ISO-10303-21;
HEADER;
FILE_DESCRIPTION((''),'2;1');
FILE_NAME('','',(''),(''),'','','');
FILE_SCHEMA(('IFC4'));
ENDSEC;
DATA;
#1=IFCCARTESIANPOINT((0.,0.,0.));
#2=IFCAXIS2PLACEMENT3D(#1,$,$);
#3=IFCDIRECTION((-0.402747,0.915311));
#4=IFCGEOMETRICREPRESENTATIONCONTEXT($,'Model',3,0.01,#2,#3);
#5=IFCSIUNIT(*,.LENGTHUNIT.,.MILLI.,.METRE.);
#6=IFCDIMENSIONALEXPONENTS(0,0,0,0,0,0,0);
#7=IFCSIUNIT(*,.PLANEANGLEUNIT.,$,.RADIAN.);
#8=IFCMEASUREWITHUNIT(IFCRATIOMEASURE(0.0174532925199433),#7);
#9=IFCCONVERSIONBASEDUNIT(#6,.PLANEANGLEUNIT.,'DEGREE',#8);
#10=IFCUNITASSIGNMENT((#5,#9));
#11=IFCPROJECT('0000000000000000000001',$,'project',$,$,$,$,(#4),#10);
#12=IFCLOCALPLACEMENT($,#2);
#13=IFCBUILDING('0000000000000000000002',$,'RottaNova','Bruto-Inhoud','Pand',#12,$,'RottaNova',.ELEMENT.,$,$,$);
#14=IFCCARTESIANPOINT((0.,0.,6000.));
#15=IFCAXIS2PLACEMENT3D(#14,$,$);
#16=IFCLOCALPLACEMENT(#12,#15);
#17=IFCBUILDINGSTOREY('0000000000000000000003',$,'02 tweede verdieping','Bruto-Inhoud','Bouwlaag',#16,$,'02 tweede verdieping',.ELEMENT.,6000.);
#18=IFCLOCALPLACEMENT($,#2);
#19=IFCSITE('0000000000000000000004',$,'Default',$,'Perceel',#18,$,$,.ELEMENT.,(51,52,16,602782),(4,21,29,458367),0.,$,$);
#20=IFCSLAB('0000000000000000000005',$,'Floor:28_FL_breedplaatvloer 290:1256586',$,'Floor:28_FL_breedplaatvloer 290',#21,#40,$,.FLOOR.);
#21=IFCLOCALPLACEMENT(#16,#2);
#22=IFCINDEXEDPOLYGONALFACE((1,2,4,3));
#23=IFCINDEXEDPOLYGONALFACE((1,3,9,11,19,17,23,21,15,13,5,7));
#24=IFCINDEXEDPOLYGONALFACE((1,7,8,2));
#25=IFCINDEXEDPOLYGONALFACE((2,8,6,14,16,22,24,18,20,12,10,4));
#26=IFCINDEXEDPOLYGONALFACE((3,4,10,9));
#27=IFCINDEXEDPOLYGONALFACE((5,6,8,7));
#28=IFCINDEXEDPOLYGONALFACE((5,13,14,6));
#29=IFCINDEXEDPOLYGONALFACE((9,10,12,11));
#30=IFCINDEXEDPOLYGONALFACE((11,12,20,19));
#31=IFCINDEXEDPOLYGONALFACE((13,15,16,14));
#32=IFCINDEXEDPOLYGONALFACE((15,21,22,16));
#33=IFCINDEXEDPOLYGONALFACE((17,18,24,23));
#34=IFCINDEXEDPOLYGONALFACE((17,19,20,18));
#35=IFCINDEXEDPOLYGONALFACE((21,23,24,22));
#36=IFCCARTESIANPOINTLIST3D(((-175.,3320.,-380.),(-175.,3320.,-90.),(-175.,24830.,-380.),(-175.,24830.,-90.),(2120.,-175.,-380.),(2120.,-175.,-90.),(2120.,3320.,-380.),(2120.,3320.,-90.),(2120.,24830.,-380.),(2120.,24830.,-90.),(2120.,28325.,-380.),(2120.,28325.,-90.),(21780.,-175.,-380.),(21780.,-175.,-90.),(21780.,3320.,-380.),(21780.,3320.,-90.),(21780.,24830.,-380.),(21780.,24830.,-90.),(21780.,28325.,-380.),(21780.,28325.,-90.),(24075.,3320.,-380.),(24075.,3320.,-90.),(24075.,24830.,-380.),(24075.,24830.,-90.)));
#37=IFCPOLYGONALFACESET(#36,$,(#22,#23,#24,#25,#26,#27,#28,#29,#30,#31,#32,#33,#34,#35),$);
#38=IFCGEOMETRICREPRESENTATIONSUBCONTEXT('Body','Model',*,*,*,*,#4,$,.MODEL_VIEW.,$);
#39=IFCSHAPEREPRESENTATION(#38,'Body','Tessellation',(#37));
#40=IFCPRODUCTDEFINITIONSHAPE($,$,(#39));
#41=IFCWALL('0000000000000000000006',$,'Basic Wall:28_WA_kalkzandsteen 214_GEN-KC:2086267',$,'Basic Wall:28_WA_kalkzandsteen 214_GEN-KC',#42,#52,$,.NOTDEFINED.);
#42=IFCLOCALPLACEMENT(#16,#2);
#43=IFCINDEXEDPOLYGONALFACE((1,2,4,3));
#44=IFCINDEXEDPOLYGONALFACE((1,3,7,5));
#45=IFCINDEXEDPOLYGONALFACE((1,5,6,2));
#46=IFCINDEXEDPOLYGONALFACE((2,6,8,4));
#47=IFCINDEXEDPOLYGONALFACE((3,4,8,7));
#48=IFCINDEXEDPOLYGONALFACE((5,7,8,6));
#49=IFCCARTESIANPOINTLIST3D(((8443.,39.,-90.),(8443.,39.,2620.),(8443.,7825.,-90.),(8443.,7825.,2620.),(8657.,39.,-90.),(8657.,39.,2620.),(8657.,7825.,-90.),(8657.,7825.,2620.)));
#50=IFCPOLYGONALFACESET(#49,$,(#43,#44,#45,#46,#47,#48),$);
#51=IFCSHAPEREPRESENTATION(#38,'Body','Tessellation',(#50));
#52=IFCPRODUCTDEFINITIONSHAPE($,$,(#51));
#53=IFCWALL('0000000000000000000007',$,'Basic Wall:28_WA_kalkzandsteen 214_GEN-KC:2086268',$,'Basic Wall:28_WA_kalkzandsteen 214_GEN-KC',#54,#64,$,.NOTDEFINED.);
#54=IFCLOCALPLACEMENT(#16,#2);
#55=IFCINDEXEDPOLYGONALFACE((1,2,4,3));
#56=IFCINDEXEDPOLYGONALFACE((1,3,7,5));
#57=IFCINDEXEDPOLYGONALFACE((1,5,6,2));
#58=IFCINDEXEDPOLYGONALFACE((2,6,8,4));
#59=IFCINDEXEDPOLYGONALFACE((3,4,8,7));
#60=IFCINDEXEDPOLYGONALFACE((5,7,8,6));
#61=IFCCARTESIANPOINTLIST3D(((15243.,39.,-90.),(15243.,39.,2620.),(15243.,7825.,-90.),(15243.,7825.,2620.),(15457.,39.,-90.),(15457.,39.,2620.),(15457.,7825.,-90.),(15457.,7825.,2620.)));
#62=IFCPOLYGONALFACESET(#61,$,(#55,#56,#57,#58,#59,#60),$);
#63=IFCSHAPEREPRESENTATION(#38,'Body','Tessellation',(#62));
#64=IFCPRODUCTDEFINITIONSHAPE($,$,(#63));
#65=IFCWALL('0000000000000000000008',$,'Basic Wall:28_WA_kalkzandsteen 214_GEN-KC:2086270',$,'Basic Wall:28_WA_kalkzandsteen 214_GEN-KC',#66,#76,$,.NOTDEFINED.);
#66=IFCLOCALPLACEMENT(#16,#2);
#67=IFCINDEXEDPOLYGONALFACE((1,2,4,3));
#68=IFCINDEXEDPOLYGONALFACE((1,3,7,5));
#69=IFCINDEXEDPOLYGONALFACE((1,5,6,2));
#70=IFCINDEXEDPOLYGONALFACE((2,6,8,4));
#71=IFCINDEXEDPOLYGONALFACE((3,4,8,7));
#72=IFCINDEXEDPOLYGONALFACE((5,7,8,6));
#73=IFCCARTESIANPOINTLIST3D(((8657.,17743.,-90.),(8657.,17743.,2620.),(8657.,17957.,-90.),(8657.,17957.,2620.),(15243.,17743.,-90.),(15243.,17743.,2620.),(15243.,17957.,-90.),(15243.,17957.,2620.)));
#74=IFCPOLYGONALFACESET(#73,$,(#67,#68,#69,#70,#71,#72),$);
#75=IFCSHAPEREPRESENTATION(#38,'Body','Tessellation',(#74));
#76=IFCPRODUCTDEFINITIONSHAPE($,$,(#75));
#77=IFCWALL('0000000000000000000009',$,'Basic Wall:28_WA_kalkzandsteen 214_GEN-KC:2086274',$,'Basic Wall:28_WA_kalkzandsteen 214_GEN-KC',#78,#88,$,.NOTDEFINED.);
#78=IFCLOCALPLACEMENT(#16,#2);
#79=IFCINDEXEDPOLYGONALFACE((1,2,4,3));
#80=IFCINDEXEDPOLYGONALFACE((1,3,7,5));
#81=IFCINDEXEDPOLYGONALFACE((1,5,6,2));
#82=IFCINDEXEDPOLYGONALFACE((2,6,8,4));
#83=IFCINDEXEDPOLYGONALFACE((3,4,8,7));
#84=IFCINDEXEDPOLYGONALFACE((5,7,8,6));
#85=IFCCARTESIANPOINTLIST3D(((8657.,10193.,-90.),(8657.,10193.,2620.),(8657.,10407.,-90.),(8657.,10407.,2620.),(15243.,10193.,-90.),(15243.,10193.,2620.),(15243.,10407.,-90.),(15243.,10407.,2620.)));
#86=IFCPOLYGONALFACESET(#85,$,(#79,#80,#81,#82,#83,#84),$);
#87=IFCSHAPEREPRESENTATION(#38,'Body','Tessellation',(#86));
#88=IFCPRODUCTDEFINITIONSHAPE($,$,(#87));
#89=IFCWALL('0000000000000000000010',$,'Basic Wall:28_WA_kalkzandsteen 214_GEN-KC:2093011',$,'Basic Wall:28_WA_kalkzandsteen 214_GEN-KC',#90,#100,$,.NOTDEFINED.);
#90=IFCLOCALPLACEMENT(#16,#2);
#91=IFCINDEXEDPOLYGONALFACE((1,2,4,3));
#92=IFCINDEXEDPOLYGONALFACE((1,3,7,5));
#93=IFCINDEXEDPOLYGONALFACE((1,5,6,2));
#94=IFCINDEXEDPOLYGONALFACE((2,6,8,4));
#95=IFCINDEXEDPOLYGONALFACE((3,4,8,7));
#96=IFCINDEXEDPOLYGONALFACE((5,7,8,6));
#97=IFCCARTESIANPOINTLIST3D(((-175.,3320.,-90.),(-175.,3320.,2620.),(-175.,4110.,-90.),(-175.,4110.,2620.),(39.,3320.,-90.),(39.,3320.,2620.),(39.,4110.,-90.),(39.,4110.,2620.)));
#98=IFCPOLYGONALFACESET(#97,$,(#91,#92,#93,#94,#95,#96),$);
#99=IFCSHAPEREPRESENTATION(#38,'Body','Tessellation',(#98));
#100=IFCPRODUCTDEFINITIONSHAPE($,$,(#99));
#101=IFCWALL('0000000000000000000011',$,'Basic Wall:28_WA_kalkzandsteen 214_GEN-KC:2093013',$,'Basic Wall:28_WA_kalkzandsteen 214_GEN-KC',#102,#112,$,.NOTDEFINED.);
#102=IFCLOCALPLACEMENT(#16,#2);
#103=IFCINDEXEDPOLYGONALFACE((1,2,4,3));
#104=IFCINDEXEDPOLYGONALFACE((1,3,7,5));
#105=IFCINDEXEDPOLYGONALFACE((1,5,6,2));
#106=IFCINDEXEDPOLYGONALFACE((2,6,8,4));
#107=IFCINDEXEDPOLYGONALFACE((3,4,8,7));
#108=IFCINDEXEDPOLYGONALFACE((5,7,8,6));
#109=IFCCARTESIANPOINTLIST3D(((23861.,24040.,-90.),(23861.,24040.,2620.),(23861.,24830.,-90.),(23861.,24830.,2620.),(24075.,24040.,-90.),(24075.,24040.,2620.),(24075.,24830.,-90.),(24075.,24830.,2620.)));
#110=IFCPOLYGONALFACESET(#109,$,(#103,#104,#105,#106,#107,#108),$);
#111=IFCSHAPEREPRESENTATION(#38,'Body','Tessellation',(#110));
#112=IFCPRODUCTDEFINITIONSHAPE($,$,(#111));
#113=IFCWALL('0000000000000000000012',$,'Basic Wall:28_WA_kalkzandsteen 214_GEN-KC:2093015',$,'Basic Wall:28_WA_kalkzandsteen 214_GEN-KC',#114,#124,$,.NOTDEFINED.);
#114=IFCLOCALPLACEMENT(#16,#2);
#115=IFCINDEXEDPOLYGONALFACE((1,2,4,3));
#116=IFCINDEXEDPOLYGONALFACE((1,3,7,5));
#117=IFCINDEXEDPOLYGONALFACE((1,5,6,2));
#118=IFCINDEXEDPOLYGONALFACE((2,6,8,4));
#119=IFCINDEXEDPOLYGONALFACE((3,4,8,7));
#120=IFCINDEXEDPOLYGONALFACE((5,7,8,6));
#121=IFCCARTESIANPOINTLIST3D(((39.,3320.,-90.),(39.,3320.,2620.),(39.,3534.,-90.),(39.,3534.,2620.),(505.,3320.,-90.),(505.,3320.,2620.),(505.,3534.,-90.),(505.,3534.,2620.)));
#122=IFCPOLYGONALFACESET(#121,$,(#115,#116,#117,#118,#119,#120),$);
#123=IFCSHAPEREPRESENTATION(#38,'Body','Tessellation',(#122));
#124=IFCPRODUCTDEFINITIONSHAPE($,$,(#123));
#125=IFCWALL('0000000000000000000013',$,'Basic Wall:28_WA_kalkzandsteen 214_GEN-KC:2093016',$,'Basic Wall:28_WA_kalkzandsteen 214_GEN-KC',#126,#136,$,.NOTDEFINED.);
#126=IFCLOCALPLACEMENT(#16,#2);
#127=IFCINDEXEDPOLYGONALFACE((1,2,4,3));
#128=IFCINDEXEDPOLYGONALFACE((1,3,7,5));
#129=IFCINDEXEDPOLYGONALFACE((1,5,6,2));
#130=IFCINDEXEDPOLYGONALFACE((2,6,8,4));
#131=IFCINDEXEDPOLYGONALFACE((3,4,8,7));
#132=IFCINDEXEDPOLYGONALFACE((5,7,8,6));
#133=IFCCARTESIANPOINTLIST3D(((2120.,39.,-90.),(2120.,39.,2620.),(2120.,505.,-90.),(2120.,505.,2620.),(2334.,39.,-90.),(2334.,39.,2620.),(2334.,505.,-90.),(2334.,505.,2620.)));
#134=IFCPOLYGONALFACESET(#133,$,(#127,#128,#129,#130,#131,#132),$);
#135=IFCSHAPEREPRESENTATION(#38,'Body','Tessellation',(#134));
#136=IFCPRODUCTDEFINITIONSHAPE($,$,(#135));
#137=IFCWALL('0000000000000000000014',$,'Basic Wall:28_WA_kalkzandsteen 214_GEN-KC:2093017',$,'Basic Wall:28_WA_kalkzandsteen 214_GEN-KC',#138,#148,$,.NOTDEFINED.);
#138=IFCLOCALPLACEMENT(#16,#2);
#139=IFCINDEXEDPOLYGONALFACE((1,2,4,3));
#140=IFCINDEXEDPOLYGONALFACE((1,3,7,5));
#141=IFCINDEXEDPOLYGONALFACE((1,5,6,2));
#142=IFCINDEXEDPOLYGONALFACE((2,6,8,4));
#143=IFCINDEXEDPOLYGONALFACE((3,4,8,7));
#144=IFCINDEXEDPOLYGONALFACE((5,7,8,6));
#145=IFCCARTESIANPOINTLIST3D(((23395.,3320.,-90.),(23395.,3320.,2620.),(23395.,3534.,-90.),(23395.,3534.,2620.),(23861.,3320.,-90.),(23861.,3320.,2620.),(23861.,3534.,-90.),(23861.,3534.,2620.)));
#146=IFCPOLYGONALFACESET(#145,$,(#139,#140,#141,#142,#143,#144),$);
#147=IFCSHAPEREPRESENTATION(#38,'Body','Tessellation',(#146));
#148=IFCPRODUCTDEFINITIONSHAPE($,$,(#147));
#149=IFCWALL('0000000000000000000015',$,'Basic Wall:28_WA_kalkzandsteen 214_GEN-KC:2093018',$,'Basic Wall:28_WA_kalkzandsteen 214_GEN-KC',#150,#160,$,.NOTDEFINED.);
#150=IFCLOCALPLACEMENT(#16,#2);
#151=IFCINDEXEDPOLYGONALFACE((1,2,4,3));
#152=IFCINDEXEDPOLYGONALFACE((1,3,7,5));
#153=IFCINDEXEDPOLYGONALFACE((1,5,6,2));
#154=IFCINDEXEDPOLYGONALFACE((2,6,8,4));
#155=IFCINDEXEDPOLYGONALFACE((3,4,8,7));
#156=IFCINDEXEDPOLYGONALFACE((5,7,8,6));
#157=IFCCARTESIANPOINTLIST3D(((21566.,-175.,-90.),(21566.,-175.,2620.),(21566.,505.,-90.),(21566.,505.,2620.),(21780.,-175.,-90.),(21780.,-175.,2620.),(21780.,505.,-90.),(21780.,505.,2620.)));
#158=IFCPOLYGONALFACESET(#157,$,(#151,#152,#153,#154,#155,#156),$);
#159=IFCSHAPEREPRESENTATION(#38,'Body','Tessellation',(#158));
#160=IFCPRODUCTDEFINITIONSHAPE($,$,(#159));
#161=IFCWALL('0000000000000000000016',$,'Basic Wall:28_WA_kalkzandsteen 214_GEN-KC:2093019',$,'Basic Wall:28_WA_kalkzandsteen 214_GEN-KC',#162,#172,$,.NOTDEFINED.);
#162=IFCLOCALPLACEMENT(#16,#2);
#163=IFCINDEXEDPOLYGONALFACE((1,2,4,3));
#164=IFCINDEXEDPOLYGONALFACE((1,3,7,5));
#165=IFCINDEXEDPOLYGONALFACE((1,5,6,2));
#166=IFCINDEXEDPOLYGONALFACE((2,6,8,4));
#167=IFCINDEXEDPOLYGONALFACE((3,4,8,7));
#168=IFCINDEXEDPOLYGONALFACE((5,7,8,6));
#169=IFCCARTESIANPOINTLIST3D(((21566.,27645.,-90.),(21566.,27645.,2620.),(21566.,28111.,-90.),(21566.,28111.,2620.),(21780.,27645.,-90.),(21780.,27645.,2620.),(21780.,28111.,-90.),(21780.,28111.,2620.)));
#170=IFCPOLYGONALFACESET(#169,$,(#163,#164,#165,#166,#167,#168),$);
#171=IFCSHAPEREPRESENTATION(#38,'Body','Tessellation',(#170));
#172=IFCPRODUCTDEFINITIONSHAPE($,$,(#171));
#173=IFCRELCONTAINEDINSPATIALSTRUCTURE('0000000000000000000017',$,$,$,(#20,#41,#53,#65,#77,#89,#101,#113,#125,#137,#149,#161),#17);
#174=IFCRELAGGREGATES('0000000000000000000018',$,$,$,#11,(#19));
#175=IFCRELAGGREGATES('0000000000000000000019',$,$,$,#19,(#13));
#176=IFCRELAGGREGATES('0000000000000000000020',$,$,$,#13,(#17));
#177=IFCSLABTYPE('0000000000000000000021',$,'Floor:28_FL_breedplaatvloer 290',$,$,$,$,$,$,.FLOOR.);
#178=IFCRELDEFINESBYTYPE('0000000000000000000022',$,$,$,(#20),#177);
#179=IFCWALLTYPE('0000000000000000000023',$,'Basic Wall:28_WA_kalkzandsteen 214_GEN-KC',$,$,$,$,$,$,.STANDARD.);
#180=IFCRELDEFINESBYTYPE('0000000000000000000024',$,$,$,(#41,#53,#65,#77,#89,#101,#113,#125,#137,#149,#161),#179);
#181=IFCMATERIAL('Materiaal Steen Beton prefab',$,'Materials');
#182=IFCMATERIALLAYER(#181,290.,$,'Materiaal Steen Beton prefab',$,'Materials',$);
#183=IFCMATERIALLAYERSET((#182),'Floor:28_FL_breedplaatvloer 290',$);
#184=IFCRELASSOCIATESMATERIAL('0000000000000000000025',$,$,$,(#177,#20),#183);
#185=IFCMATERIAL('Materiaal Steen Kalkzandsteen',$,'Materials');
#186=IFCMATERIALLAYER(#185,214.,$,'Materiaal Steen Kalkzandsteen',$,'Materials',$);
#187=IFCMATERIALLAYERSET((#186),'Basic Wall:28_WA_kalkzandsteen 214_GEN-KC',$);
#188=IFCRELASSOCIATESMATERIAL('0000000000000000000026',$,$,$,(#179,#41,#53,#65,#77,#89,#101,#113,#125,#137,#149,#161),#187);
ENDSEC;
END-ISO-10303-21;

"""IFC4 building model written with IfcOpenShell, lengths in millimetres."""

from ifc_helpers import new_model, entity, si_unit, converted_unit, direction, frame, frame_2d, origin, origin_2d_with_axis, place, context, subcontext, project, spatial, polyline, rectangle, outline, extrude, material, layer, layer_set, layer_usage, type_object, element, save


model = new_model("IFC4")

# Units and contexts
model_context = context("Model", 3, precision=0.01, world=origin(), true_north=direction((-0.402747, 0.915311)))
body_context = subcontext(model_context, "Body", "Model", "MODEL_VIEW")
ifc_project = project(units=[si_unit("LENGTHUNIT", "METRE", prefix="MILLI"), converted_unit("PLANEANGLEUNIT", "DEGREE", entity("IfcRatioMeasure", 0.0174532925199433), si_unit("PLANEANGLEUNIT", "RADIAN"), dimensions=[0, 0, 0, 0, 0, 0, 0])], contexts=[model_context])

# Site, building, storey
site_placement = place(None, origin())
site = spatial("IfcSite", under=ifc_project, at=site_placement, Name="Default", ObjectType="Perceel", CompositionType="ELEMENT", RefLatitude=(51, 52, 16, 602782), RefLongitude=(4, 21, 29, 458367), RefElevation=0.0)
building_placement = place(None, origin())
building = spatial("IfcBuilding", under=site, at=building_placement, Name="RottaNova", Description="Bruto-Inhoud", ObjectType="Pand", LongName="RottaNova", CompositionType="ELEMENT")
storey_placement = place(building_placement, frame((0.0, 0.0, 6000.0)))
storey = spatial("IfcBuildingStorey", under=building, at=storey_placement, Name="02 tweede verdieping", Description="Bruto-Inhoud", ObjectType="Bouwlaag", LongName="02 tweede verdieping", CompositionType="ELEMENT", Elevation=6000.0)

# Slab
ifc_material_1 = material(Name="Materiaal Steen Beton prefab", Category="Materials")
ifc_layer_1 = layer(ifc_material_1, 290.0, Name="Materiaal Steen Beton prefab", Category="Materials")
ifc_layer_set_1 = layer_set([ifc_layer_1], Name="Floor:28_FL_breedplaatvloer 290")
ifc_layer_usage = layer_usage(ifc_layer_set_1, "AXIS3", "POSITIVE", 0.0)
slab_type = type_object("IfcSlabType", Name="Floor:28_FL_breedplaatvloer 290", PredefinedType="FLOOR", material=ifc_layer_set_1)
slab_placement = place(storey_placement, frame((-175.0, -175.0, -380.0)))
element("IfcSlab", 1, at=slab_placement, inside=storey, type_object=slab_type, material=ifc_layer_usage, Name="Floor:28_FL_breedplaatvloer 290:1256586", ObjectType="Floor:28_FL_breedplaatvloer 290", PredefinedType="FLOOR", context=body_context, shape_type="SweptSolid", body=[
    extrude(outline(polyline([(-9830.0, 14250.0), (-9830.0, 10755.0), (-12125.0, 10755.0), (-12125.0, -10755.0), (-9830.0, -10755.0), (-9830.0, -14250.0), (9830.0, -14250.0), (9830.0, -10755.0), (12125.0, -10755.0), (12125.0, 10755.0), (9830.0, 10755.0), (9830.0, 14250.0), (-9830.0, 14250.0)])), frame((12125.0, 14250.0, 290.0), z_axis=(0.0, 0.0, -1.0), x_axis=(-1.0, 0.0, 0.0)), (0.0, 0.0, 1.0), 290.0),
])

# Walls
ifc_material_2 = material(Name="Materiaal Steen Kalkzandsteen", Category="Materials")
ifc_layer_2 = layer(ifc_material_2, 214.0, Name="Materiaal Steen Kalkzandsteen", Category="Materials")
ifc_layer_set_2 = layer_set([ifc_layer_2], Name="Basic Wall:28_WA_kalkzandsteen 214_GEN-KC")
wall_type_1 = type_object("IfcWallType", Name="Basic Wall:28_WA_kalkzandsteen 214_GEN-KC", PredefinedType="STANDARD", material=ifc_layer_set_2)
wall_1_placement = place(storey_placement, frame((8550.0, 39.0, -90.0), z_axis=(0.0, 0.0, 1.0), x_axis=(0.0, 1.0, 0.0)))
element("IfcWall", 2, at=wall_1_placement, inside=storey, type_object=wall_type_1, material=ifc_layer_set_2, Name="Basic Wall:28_WA_kalkzandsteen 214_GEN-KC:2086267", ObjectType="Basic Wall:28_WA_kalkzandsteen 214_GEN-KC", PredefinedType="NOTDEFINED", context=body_context, shape_type="SweptSolid", body=[
    extrude(rectangle(XDim=7786.0, YDim=214.0, at=frame_2d((0.0, 0.0), x_axis=(1.0, 0.0))), frame((3893.0, 0.0, 0.0)), (0.0, 0.0, 1.0), 2710.0),
])
wall_2_placement = place(storey_placement, frame((15350.0, 39.0, -90.0), z_axis=(0.0, 0.0, 1.0), x_axis=(0.0, 1.0, 0.0)))
element("IfcWall", 3, at=wall_2_placement, inside=storey, type_object=wall_type_1, material=ifc_layer_set_2, Name="Basic Wall:28_WA_kalkzandsteen 214_GEN-KC:2086268", ObjectType="Basic Wall:28_WA_kalkzandsteen 214_GEN-KC", PredefinedType="NOTDEFINED", context=body_context, shape_type="SweptSolid", body=[
    extrude(rectangle(XDim=7786.0, YDim=214.0, at=origin_2d_with_axis()), frame((3893.0, 0.0, 0.0)), (0.0, 0.0, 1.0), 2710.0),
])
wall_3_placement = place(storey_placement, frame((8657.0, 17850.0, -90.0)))
element("IfcWall", 4, at=wall_3_placement, inside=storey, type_object=wall_type_1, material=ifc_layer_set_2, Name="Basic Wall:28_WA_kalkzandsteen 214_GEN-KC:2086270", ObjectType="Basic Wall:28_WA_kalkzandsteen 214_GEN-KC", PredefinedType="NOTDEFINED", context=body_context, shape_type="SweptSolid", body=[
    extrude(rectangle(XDim=6586.0, YDim=214.0, at=frame_2d((3293.0, 0.0), x_axis=(-1.0, 0.0))), origin(), (0.0, 0.0, 1.0), 2710.0),
])
wall_4_placement = place(storey_placement, frame((8657.0, 10300.0, -90.0)))
element("IfcWall", 5, at=wall_4_placement, inside=storey, type_object=wall_type_1, material=ifc_layer_set_2, Name="Basic Wall:28_WA_kalkzandsteen 214_GEN-KC:2086274", ObjectType="Basic Wall:28_WA_kalkzandsteen 214_GEN-KC", PredefinedType="NOTDEFINED", context=body_context, shape_type="SweptSolid", body=[
    extrude(rectangle(XDim=6586.0, YDim=214.0, at=frame_2d((3293.0, 0.0), x_axis=(-1.0, 0.0))), origin(), (0.0, 0.0, 1.0), 2710.0),
])
wall_5_placement = place(storey_placement, frame((-68.0, 3320.0, -90.0), z_axis=(0.0, 0.0, 1.0), x_axis=(0.0, 1.0, 0.0)))
element("IfcWall", 6, at=wall_5_placement, inside=storey, type_object=wall_type_1, material=ifc_layer_set_2, Name="Basic Wall:28_WA_kalkzandsteen 214_GEN-KC:2093011", ObjectType="Basic Wall:28_WA_kalkzandsteen 214_GEN-KC", PredefinedType="NOTDEFINED", context=body_context, shape_type="SweptSolid", body=[
    extrude(rectangle(XDim=790.0, YDim=214.0, at=frame_2d((395.0, 0.0), x_axis=(-1.0, 0.0))), origin(), (0.0, 0.0, 1.0), 2710.0),
])
wall_6_placement = place(storey_placement, frame((23968.0, 24830.0, -90.0), z_axis=(0.0, 0.0, 1.0), x_axis=(0.0, -1.0, 0.0)))
element("IfcWall", 7, at=wall_6_placement, inside=storey, type_object=wall_type_1, material=ifc_layer_set_2, Name="Basic Wall:28_WA_kalkzandsteen 214_GEN-KC:2093013", ObjectType="Basic Wall:28_WA_kalkzandsteen 214_GEN-KC", PredefinedType="NOTDEFINED", context=body_context, shape_type="SweptSolid", body=[
    extrude(rectangle(XDim=790.0, YDim=214.0, at=frame_2d((395.0, 0.0), x_axis=(-1.0, 0.0))), origin(), (0.0, 0.0, 1.0), 2710.0),
])
wall_7_placement = place(storey_placement, frame((39.0, 3427.0, -90.0)))
element("IfcWall", 8, at=wall_7_placement, inside=storey, type_object=wall_type_1, material=ifc_layer_set_2, Name="Basic Wall:28_WA_kalkzandsteen 214_GEN-KC:2093015", ObjectType="Basic Wall:28_WA_kalkzandsteen 214_GEN-KC", PredefinedType="NOTDEFINED", context=body_context, shape_type="SweptSolid", body=[
    extrude(rectangle(XDim=466.0, YDim=214.0, at=frame_2d((233.0, 0.0), x_axis=(-1.0, 0.0))), origin(), (0.0, 0.0, 1.0), 2710.0),
])
wall_8_placement = place(storey_placement, frame((2227.0, 505.0, -90.0), z_axis=(0.0, 0.0, 1.0), x_axis=(0.0, -1.0, 0.0)))
element("IfcWall", 9, at=wall_8_placement, inside=storey, type_object=wall_type_1, material=ifc_layer_set_2, Name="Basic Wall:28_WA_kalkzandsteen 214_GEN-KC:2093016", ObjectType="Basic Wall:28_WA_kalkzandsteen 214_GEN-KC", PredefinedType="NOTDEFINED", context=body_context, shape_type="SweptSolid", body=[
    extrude(rectangle(XDim=466.0, YDim=214.0, at=frame_2d((233.0, 0.0), x_axis=(-1.0, 0.0))), origin(), (0.0, 0.0, 1.0), 2710.0),
])
wall_9_placement = place(storey_placement, frame((23861.0, 3427.0, -90.0), z_axis=(0.0, 0.0, 1.0), x_axis=(-1.0, 0.0, 0.0)))
element("IfcWall", 10, at=wall_9_placement, inside=storey, type_object=wall_type_1, material=ifc_layer_set_2, Name="Basic Wall:28_WA_kalkzandsteen 214_GEN-KC:2093017", ObjectType="Basic Wall:28_WA_kalkzandsteen 214_GEN-KC", PredefinedType="NOTDEFINED", context=body_context, shape_type="SweptSolid", body=[
    extrude(rectangle(XDim=466.0, YDim=214.0, at=frame_2d((233.0, 0.0), x_axis=(-1.0, 0.0))), origin(), (0.0, 0.0, 1.0), 2710.0),
])
wall_10_placement = place(storey_placement, frame((21673.0, -175.0, -90.0), z_axis=(0.0, 0.0, 1.0), x_axis=(0.0, 1.0, 0.0)))
element("IfcWall", 11, at=wall_10_placement, inside=storey, type_object=wall_type_1, material=ifc_layer_set_2, Name="Basic Wall:28_WA_kalkzandsteen 214_GEN-KC:2093018", ObjectType="Basic Wall:28_WA_kalkzandsteen 214_GEN-KC", PredefinedType="NOTDEFINED", context=body_context, shape_type="SweptSolid", body=[
    extrude(rectangle(XDim=680.0, YDim=214.0, at=frame_2d((340.0, 0.0), x_axis=(-1.0, 0.0))), origin(), (0.0, 0.0, 1.0), 2710.0),
])
wall_11_placement = place(storey_placement, frame((21673.0, 28111.0, -90.0), z_axis=(0.0, 0.0, 1.0), x_axis=(0.0, -1.0, 0.0)))
element("IfcWall", 12, at=wall_11_placement, inside=storey, type_object=wall_type_1, material=ifc_layer_set_2, Name="Basic Wall:28_WA_kalkzandsteen 214_GEN-KC:2093019", ObjectType="Basic Wall:28_WA_kalkzandsteen 214_GEN-KC", PredefinedType="NOTDEFINED", context=body_context, shape_type="SweptSolid", body=[
    extrude(rectangle(XDim=466.0, YDim=214.0, at=frame_2d((233.0, 0.0), x_axis=(-1.0, 0.0))), origin(), (0.0, 0.0, 1.0), 2710.0),
])

save(model, "model.ifc")
